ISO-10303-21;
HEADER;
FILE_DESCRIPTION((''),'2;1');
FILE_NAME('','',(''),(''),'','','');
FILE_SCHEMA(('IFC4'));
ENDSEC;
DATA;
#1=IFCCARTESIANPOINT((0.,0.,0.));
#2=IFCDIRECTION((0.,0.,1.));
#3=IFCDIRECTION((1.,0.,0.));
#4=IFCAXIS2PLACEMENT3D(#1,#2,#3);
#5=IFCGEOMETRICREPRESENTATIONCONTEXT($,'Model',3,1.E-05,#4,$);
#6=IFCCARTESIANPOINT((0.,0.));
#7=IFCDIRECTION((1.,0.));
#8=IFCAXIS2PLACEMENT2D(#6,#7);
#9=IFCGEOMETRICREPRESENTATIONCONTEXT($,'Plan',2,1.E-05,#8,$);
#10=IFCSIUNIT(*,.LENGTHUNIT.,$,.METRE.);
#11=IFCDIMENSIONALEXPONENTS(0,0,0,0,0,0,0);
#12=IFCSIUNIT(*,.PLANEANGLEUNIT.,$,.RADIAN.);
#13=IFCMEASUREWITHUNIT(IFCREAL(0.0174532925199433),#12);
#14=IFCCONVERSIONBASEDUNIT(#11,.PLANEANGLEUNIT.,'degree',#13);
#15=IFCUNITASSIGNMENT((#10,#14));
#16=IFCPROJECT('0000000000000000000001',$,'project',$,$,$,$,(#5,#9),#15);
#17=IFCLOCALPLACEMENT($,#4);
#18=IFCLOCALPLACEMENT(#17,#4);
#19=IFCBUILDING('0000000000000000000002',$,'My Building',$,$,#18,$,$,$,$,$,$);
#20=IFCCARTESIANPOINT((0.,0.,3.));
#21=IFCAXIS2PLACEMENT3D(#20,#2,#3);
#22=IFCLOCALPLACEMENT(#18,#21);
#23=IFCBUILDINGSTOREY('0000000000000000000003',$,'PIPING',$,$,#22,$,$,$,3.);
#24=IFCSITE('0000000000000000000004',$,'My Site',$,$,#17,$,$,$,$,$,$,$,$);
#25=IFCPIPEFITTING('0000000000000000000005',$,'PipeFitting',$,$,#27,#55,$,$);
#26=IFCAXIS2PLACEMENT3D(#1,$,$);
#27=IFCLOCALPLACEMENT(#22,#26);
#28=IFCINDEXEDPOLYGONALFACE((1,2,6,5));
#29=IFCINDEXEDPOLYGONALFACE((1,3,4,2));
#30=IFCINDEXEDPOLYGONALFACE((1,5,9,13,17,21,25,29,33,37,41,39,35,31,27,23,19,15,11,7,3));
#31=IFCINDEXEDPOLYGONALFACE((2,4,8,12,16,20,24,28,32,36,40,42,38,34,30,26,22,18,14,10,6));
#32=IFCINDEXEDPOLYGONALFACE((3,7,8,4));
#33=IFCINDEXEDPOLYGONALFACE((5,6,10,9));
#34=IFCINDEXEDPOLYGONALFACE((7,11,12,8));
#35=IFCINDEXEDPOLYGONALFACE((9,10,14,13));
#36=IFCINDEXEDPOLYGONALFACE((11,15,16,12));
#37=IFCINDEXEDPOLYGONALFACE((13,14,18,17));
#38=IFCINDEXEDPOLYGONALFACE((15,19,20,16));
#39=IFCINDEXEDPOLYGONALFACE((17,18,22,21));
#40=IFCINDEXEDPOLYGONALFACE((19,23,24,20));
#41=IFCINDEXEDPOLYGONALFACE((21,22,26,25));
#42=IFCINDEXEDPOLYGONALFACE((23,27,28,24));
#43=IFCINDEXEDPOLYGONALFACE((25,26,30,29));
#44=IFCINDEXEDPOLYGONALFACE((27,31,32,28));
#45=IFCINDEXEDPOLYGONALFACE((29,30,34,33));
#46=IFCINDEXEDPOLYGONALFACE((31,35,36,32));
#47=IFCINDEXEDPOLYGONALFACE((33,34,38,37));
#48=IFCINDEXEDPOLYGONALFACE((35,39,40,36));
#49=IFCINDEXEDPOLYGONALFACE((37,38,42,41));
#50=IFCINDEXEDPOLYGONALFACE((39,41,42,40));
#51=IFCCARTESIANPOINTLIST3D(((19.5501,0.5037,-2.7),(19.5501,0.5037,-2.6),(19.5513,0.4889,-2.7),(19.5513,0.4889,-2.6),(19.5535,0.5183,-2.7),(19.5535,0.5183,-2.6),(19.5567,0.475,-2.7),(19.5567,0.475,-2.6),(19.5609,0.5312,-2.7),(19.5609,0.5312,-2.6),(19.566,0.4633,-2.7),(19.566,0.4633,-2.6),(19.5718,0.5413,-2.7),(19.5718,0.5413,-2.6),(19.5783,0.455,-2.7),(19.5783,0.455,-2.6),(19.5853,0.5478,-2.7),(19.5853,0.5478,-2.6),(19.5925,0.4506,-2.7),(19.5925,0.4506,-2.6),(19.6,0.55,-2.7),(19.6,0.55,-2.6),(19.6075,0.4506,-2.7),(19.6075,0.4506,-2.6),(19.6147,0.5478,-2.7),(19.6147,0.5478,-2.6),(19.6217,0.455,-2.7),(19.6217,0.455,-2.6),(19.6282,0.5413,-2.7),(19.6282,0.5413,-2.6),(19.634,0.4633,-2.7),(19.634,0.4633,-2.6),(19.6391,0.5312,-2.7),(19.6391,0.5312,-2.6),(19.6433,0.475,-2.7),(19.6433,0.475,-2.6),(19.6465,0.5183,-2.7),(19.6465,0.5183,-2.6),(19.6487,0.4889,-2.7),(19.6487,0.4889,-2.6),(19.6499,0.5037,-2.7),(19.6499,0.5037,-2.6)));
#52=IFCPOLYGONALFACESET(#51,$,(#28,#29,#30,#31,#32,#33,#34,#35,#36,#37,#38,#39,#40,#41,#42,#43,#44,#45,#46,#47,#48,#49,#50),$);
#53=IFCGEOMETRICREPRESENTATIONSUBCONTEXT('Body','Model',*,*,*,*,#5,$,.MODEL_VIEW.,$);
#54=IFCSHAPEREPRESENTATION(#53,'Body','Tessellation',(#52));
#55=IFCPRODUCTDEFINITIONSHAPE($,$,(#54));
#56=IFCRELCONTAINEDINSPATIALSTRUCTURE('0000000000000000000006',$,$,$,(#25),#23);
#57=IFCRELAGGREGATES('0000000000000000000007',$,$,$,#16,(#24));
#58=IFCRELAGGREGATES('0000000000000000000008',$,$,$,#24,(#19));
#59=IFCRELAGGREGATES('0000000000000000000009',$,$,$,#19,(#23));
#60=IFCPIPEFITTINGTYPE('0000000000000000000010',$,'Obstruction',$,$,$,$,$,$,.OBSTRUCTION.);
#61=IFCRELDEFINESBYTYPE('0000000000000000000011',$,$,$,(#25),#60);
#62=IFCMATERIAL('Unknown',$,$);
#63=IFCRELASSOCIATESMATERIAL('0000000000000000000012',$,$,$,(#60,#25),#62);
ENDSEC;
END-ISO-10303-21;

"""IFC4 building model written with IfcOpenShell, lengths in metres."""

from ifc_helpers import new_model, entity, si_unit, converted_unit, frame, origin_with_axes, origin_2d_with_axis, place, context, subcontext, project, spatial, circle, extrude, material, material_profile, profile_set, profile_usage, type_object, element, save


model = new_model("IFC4")

# Units and contexts
model_context = context("Model", 3, precision=1e-05, world=origin_with_axes())
plan_context = context("Plan", 2, precision=1e-05, world=origin_2d_with_axis())
body_context = subcontext(model_context, "Body", "Model", "MODEL_VIEW")
ifc_project = project(units=[si_unit("LENGTHUNIT", "METRE"), converted_unit("PLANEANGLEUNIT", "degree", entity("IfcReal", 0.0174532925199433), si_unit("PLANEANGLEUNIT", "RADIAN"), dimensions=[0, 0, 0, 0, 0, 0, 0])], contexts=[model_context, plan_context])

# Site, building, storey
site_placement = place(None, origin_with_axes())
site = spatial("IfcSite", under=ifc_project, at=site_placement, Name="My Site")
building_placement = place(site_placement, origin_with_axes())
building = spatial("IfcBuilding", under=site, at=building_placement, Name="My Building")
storey_placement = place(building_placement, frame((0.0, 0.0, 3.0), z_axis=(0.0, 0.0, 1.0), x_axis=(1.0, 0.0, 0.0)))
storey = spatial("IfcBuildingStorey", under=building, at=storey_placement, Name="PIPING", Elevation=3.0)

# Shared definitions
ifc_material = material(Name="Unknown")

# Pipe fitting
ifc_material_profile_1 = material_profile(ifc_material, circle(Radius=0.05))
ifc_profile_set_1 = profile_set([ifc_material_profile_1])
pipe_fitting_type = type_object("IfcPipeFittingType", Name="Obstruction", PredefinedType="OBSTRUCTION", material=ifc_profile_set_1)
ifc_profile_usage_1 = profile_usage(ifc_profile_set_1, cardinal=5)
pipe_fitting_1_placement = place(storey_placement, frame((19.6, 0.5, -2.6), z_axis=(0.0, 0.0, -1.0), x_axis=(0.0, 1.0, 0.0)))
element("IfcPipeFitting", 1, at=pipe_fitting_1_placement, inside=storey, type_object=pipe_fitting_type, material=ifc_profile_usage_1, Name="PipeFitting", context=body_context, shape_type="SweptSolid", body=[
    extrude(circle(Radius=0.05), origin_with_axes(), (0.0, 0.0, 1.0), 0.1),
])

save(model, "model.ifc")
